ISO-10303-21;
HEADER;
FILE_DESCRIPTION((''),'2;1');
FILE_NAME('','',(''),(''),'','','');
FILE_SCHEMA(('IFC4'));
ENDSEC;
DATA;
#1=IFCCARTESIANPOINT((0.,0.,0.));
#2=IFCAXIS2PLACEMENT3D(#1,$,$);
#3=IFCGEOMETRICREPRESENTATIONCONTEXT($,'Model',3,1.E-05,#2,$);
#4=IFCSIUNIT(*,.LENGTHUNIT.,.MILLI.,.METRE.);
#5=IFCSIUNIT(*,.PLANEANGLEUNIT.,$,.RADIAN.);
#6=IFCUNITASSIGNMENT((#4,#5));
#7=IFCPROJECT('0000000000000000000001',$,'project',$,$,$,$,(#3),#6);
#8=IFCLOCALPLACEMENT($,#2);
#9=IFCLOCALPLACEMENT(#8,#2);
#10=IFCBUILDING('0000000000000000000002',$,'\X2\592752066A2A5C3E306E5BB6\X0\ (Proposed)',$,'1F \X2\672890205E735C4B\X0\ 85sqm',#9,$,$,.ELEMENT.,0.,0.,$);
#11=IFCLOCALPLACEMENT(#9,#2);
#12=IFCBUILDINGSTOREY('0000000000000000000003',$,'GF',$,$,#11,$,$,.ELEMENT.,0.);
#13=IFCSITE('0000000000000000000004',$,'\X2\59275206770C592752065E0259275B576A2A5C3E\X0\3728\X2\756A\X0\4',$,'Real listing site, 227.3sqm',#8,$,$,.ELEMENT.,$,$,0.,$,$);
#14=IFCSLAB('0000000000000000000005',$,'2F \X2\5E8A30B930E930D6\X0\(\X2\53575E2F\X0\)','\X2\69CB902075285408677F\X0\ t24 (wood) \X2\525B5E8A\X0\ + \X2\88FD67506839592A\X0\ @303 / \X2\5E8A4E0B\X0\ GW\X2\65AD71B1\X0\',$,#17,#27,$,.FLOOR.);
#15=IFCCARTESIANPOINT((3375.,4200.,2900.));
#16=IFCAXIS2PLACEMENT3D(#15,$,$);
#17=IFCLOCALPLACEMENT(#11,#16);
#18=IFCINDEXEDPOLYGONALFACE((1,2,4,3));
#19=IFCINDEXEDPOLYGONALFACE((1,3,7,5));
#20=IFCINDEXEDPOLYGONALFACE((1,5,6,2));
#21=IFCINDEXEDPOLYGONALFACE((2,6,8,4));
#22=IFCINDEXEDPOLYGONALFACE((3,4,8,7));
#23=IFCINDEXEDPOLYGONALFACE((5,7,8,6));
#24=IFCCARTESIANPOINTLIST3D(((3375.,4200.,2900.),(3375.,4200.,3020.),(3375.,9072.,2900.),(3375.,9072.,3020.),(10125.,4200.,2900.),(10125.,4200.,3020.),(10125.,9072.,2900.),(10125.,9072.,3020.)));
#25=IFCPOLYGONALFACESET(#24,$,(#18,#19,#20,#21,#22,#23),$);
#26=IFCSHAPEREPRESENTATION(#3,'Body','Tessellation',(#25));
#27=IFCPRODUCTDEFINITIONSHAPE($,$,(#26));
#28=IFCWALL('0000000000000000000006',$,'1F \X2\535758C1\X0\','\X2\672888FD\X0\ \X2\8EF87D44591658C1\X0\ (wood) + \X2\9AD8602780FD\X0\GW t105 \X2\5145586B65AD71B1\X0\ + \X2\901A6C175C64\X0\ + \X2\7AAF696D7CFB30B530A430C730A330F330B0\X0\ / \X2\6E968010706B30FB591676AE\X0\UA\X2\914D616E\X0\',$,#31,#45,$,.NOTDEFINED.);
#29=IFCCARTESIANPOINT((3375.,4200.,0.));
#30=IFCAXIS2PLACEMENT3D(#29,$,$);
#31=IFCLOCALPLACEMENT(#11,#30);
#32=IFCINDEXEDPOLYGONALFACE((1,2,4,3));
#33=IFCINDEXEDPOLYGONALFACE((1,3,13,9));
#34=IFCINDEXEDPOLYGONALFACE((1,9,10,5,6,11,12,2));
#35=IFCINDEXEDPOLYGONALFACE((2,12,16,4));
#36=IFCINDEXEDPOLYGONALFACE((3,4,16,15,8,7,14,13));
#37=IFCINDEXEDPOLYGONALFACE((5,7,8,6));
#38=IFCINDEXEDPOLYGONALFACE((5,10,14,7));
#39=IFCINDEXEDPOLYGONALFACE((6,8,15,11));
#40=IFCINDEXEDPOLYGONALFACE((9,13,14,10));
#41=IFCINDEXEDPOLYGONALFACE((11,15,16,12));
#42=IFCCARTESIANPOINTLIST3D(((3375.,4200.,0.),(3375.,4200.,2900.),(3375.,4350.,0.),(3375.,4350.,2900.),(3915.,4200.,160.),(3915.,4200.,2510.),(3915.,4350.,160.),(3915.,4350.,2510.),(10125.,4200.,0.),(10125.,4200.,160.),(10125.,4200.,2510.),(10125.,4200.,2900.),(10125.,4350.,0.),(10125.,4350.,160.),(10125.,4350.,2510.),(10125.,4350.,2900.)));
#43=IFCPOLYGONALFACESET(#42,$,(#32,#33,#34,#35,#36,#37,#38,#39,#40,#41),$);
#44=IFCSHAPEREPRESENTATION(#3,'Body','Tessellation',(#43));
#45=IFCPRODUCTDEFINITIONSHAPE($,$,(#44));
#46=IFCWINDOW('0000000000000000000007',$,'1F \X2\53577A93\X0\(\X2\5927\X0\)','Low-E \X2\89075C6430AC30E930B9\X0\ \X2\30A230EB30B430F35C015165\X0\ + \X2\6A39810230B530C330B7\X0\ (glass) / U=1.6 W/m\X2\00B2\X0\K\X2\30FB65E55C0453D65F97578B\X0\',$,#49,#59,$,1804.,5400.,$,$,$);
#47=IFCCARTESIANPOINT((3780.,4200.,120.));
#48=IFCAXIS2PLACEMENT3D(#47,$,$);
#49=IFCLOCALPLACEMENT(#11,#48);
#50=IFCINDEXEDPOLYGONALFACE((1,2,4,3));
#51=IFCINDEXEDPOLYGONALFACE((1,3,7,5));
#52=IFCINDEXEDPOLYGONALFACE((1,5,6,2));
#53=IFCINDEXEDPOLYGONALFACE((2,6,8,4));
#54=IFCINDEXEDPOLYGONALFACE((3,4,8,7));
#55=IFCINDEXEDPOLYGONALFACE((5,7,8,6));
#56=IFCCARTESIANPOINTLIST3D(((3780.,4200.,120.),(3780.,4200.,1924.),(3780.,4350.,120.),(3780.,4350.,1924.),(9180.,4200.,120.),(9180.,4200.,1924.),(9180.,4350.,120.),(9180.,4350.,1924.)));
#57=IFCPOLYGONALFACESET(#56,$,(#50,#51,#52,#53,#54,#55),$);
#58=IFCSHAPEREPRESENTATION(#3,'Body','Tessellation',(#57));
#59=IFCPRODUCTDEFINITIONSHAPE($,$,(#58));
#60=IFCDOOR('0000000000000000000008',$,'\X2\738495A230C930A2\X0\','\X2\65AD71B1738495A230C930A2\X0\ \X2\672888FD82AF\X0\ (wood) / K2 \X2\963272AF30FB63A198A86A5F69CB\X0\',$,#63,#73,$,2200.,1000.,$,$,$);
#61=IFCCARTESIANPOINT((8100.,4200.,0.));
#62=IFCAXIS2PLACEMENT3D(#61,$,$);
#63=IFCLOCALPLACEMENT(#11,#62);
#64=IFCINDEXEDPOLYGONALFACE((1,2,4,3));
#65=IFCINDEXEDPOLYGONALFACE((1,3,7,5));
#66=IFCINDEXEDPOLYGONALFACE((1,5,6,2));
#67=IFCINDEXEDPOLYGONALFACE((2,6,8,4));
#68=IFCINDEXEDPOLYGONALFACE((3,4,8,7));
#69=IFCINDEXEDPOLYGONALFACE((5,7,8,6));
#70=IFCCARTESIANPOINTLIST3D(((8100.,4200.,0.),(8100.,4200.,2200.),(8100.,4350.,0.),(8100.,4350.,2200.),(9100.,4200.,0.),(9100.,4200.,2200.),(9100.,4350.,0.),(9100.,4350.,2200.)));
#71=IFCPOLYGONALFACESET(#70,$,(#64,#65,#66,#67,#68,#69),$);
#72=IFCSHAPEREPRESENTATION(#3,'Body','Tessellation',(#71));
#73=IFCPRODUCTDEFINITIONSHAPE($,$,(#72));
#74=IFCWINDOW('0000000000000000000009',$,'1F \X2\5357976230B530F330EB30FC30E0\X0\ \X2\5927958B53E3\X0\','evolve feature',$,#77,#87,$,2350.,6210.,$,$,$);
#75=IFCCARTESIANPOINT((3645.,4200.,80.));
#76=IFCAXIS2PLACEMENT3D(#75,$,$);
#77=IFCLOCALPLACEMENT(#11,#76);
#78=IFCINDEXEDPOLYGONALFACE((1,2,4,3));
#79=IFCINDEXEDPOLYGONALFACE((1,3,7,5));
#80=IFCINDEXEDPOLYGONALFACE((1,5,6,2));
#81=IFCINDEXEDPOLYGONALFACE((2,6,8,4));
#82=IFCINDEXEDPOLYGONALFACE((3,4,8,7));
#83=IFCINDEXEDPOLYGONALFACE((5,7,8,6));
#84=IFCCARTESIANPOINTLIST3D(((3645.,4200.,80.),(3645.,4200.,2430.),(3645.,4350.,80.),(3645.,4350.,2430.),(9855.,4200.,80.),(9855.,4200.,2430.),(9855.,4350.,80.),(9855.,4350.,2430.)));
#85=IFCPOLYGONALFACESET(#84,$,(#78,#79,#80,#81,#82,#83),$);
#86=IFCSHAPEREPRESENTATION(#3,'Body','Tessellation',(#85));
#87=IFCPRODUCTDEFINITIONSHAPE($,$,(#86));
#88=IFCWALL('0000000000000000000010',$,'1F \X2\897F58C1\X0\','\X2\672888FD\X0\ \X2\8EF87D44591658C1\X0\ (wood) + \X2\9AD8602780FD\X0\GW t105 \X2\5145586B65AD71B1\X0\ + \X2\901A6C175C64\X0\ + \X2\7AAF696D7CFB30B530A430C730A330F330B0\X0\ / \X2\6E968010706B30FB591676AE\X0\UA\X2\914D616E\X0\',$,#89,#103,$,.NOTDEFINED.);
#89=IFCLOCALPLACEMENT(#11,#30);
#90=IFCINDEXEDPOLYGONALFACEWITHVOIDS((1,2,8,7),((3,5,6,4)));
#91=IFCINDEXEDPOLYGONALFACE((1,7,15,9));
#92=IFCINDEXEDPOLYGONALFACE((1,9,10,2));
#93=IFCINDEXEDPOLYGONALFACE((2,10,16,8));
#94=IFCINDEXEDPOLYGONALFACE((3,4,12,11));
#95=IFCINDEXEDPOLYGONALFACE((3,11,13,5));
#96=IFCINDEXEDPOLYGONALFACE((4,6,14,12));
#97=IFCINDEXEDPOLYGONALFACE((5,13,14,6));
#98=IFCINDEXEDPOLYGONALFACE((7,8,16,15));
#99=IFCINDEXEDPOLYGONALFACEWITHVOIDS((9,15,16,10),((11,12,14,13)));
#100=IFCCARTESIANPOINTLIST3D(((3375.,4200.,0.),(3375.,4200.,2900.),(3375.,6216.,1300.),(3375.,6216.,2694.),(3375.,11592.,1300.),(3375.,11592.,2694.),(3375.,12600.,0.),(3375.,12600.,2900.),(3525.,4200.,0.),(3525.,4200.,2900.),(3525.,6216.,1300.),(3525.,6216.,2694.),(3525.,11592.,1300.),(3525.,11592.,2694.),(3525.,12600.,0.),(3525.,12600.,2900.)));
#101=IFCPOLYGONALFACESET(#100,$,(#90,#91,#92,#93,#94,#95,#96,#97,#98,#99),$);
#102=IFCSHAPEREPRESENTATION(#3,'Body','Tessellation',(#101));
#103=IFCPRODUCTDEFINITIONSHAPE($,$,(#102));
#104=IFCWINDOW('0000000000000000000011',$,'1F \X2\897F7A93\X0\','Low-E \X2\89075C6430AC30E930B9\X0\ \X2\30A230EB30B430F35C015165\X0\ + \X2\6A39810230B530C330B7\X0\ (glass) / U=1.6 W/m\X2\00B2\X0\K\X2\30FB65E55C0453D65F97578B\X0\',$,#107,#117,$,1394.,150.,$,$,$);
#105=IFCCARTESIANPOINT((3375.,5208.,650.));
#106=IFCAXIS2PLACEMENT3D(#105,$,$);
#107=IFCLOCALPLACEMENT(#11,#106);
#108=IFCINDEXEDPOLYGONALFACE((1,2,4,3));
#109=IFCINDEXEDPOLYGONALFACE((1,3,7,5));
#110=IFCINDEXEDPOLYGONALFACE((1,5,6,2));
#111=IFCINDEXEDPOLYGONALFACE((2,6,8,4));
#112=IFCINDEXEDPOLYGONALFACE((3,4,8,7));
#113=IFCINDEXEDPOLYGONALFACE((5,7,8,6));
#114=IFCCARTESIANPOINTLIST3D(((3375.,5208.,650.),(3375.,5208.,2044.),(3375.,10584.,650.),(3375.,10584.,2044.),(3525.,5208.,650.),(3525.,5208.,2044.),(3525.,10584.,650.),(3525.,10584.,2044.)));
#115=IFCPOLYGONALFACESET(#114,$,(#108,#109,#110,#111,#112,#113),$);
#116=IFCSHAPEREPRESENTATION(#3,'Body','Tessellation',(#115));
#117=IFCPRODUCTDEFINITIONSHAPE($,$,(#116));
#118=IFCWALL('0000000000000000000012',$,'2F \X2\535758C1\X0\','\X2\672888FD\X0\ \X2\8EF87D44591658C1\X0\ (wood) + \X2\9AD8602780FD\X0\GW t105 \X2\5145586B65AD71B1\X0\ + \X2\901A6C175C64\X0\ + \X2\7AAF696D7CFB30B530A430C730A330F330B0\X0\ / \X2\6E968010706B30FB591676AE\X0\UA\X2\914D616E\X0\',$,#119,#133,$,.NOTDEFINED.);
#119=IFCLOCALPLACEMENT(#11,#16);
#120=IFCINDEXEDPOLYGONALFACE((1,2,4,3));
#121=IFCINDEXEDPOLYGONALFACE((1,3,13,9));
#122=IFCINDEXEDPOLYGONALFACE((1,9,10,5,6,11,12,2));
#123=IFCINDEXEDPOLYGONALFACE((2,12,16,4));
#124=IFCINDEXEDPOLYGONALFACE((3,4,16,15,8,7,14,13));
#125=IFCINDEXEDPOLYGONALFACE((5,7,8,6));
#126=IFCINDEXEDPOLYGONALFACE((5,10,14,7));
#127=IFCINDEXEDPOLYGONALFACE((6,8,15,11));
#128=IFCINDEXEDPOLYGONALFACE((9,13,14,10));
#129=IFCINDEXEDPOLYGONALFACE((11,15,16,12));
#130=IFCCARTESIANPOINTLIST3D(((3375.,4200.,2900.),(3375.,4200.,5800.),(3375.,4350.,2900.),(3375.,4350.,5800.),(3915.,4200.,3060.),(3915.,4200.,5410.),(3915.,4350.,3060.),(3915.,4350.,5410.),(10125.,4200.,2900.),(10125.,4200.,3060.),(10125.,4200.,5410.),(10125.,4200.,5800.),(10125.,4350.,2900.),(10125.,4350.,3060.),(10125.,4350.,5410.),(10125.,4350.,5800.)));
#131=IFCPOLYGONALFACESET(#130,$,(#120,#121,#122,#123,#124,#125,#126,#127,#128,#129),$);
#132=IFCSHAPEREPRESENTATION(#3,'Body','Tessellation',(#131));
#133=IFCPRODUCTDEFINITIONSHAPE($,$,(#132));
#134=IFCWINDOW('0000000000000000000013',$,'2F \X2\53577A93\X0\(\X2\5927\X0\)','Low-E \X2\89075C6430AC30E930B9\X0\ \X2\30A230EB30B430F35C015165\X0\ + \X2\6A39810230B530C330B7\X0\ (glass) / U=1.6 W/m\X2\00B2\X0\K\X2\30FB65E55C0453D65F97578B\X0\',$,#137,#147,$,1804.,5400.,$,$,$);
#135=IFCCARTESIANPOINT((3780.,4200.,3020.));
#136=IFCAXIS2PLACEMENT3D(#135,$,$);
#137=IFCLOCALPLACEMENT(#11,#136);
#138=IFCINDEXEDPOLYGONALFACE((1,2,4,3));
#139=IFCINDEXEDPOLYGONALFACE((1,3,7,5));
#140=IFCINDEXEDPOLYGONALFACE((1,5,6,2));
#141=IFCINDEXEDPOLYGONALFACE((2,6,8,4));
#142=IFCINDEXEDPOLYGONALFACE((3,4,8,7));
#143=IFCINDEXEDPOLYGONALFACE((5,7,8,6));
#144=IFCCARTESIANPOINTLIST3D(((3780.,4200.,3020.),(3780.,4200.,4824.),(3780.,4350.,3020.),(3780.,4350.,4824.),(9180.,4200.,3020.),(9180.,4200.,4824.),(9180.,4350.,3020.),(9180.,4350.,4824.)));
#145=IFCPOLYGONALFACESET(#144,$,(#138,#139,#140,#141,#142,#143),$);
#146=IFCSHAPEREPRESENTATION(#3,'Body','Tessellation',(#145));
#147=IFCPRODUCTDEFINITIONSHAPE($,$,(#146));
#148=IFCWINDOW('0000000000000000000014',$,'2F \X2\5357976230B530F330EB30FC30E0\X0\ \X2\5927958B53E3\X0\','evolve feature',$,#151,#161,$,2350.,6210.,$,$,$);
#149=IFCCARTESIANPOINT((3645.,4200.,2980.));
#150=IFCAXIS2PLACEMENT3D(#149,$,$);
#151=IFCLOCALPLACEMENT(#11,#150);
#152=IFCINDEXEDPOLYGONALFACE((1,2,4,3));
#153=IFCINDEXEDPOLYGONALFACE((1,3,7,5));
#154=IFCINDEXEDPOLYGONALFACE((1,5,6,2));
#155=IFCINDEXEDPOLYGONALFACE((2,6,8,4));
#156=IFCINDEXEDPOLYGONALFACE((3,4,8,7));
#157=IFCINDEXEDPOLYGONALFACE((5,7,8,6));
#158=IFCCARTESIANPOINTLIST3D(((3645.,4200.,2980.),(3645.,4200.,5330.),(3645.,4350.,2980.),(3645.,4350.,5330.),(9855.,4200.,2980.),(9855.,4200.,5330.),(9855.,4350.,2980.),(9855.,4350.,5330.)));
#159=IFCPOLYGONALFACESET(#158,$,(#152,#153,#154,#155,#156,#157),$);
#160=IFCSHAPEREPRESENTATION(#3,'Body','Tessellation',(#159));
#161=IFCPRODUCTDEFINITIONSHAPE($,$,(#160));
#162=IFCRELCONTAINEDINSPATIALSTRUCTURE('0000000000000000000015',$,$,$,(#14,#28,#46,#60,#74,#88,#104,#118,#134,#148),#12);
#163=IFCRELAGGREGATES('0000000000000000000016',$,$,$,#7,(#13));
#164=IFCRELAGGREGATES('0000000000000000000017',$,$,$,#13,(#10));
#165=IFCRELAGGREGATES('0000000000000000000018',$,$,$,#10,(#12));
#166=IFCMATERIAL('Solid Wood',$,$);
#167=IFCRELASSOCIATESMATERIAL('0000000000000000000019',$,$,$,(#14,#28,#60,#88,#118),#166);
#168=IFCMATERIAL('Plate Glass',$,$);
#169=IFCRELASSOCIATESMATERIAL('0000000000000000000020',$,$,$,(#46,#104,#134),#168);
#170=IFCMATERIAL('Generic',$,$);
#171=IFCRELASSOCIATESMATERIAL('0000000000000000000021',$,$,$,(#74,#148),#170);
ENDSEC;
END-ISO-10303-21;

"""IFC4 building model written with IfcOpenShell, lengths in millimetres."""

from ifc_helpers import new_model, si_unit, frame, frame_2d, origin, place, context, project, spatial, rectangle, extrude, material, element, fill, save


model = new_model("IFC4")

# Units and contexts
model_context = context("Model", 3, precision=1e-05, world=origin())
ifc_project = project(units=[si_unit("LENGTHUNIT", "METRE", prefix="MILLI"), si_unit("PLANEANGLEUNIT", "RADIAN")], contexts=[model_context])

# Site, building, storey
site_placement = place(None, origin())
site = spatial("IfcSite", under=ifc_project, at=site_placement, Name="大分県大分市大字横尾3728番4", ObjectType="Real listing site, 227.3sqm", CompositionType="ELEMENT", RefElevation=0.0)
building_placement = place(site_placement, origin())
building = spatial("IfcBuilding", under=site, at=building_placement, Name="大分横尾の家 (Proposed)", ObjectType="1F 木造平屋 85sqm", CompositionType="ELEMENT", ElevationOfRefHeight=0.0, ElevationOfTerrain=0.0)
storey_placement = place(building_placement, origin())
storey = spatial("IfcBuildingStorey", under=building, at=storey_placement, Name="GF", CompositionType="ELEMENT", Elevation=0.0)

# Slab
ifc_material_1 = material(Name="Solid Wood")
slab_1_placement = place(storey_placement, frame((3375.0, 4200.0, 2900.0)))
element("IfcSlab", 1, at=slab_1_placement, inside=storey, material=ifc_material_1, Name="2F 床スラブ(南帯)", Description="構造用合板 t24 (wood) 剛床 + 製材根太 @303 / 床下 GW断熱", PredefinedType="FLOOR", context=model_context, shape_type="SweptSolid", body=[
    extrude(rectangle(XDim=6750.0, YDim=4872.0, at=frame_2d((3375.0, 2436.0))), frame((3375.0, 4200.0, 2900.0)), (0.0, 0.0, 1.0), 120.0),
])
ifc_material_2 = material(Name="Generic")

# Wall, openings, windows, door
wall_1_placement = place(storey_placement, frame((3375.0, 4200.0, 0.0)))
wall_1 = element("IfcWall", 2, at=wall_1_placement, inside=storey, material=ifc_material_1, Name="1F 南壁", Description="木製 軸組外壁 (wood) + 高性能GW t105 充填断熱 + 通気層 + 窯業系サイディング / 準耐火・外皮UA配慮", PredefinedType="NOTDEFINED", context=model_context, shape_type="SweptSolid", body=[
    extrude(rectangle(XDim=6750.0, YDim=150.0, at=frame_2d((3375.0, 75.0))), frame((3375.0, 4200.0, 0.0)), (0.0, 0.0, 1.0), 2900.0),
])
opening_1_placement = place(storey_placement, frame((3780.0, 4200.0, 120.0)))
opening_1 = element("IfcOpeningElement", 3, at=opening_1_placement, cuts=wall_1, PredefinedType="NOTDEFINED", context=model_context, shape_type="SweptSolid", body=[
    extrude(rectangle(XDim=5400.0, YDim=150.0, at=frame_2d((2700.0, 75.0))), frame((3780.0, 4200.0, 120.0)), (0.0, 0.0, 1.0), 1804.0),
])
opening_2_placement = place(storey_placement, frame((8100.0, 4200.0, 0.0)))
opening_2 = element("IfcOpeningElement", 4, at=opening_2_placement, cuts=wall_1, PredefinedType="NOTDEFINED", context=model_context, shape_type="SweptSolid", body=[
    extrude(rectangle(XDim=1000.0, YDim=150.0, at=frame_2d((500.0, 75.0))), frame((8100.0, 4200.0, 0.0)), (0.0, 0.0, 1.0), 2200.0),
])
opening_3_placement = place(storey_placement, frame((3645.0, 4200.0, 80.0)))
opening_3 = element("IfcOpeningElement", 5, at=opening_3_placement, cuts=wall_1, PredefinedType="NOTDEFINED", context=model_context, shape_type="SweptSolid", body=[
    extrude(rectangle(XDim=6210.0, YDim=150.0, at=frame_2d((3105.0, 75.0))), frame((3645.0, 4200.0, 80.0)), (0.0, 0.0, 1.0), 2350.0),
])
ifc_material_3 = material(Name="Plate Glass")
window_1_placement = place(storey_placement, frame((3780.0, 4200.0, 120.0)))
window_1 = element("IfcWindow", 6, at=window_1_placement, inside=storey, material=ifc_material_3, Name="1F 南窓(大)", Description="Low-E 複層ガラス アルゴン封入 + 樹脂サッシ (glass) / U=1.6 W/m²K・日射取得型", OverallHeight=1804.0, OverallWidth=5400.0, context=model_context, shape_type="SweptSolid", body=[
    extrude(rectangle(XDim=5400.0, YDim=150.0, at=frame_2d((2700.0, 75.0))), frame((3780.0, 4200.0, 120.0)), (0.0, 0.0, 1.0), 1804.0),
])
fill(opening_1, window_1)
door_placement = place(storey_placement, frame((8100.0, 4200.0, 0.0)))
door = element("IfcDoor", 7, at=door_placement, inside=storey, material=ifc_material_1, Name="玄関ドア", Description="断熱玄関ドア 木製芯 (wood) / K2 防犯・採風機構", OverallHeight=2200.0, OverallWidth=1000.0, context=model_context, shape_type="SweptSolid", body=[
    extrude(rectangle(XDim=1000.0, YDim=150.0, at=frame_2d((500.0, 75.0))), frame((8100.0, 4200.0, 0.0)), (0.0, 0.0, 1.0), 2200.0),
])
fill(opening_2, door)
window_2_placement = place(storey_placement, frame((3645.0, 4200.0, 80.0)))
window_2 = element("IfcWindow", 8, at=window_2_placement, inside=storey, material=ifc_material_2, Name="1F 南面サンルーム 大開口", Description="evolve feature", OverallHeight=2350.0, OverallWidth=6210.0, context=model_context, shape_type="SweptSolid", body=[
    extrude(rectangle(XDim=6210.0, YDim=150.0, at=frame_2d((3105.0, 75.0))), frame((3645.0, 4200.0, 80.0)), (0.0, 0.0, 1.0), 2350.0),
])
fill(opening_3, window_2)

# Wall, opening, window
wall_2_placement = place(storey_placement, frame((3375.0, 4200.0, 0.0)))
wall_2 = element("IfcWall", 9, at=wall_2_placement, inside=storey, material=ifc_material_1, Name="1F 西壁", Description="木製 軸組外壁 (wood) + 高性能GW t105 充填断熱 + 通気層 + 窯業系サイディング / 準耐火・外皮UA配慮", PredefinedType="NOTDEFINED", context=model_context, shape_type="SweptSolid", body=[
    extrude(rectangle(XDim=150.0, YDim=8400.0, at=frame_2d((75.0, 4200.0))), frame((3375.0, 4200.0, 0.0)), (0.0, 0.0, 1.0), 2900.0),
])
opening_4_placement = place(storey_placement, frame((3375.0, 5208.0, 650.0)))
opening_4 = element("IfcOpeningElement", 10, at=opening_4_placement, cuts=wall_2, PredefinedType="NOTDEFINED", context=model_context, shape_type="SweptSolid", body=[
    extrude(rectangle(XDim=150.0, YDim=5376.0, at=frame_2d((75.0, 2688.0))), frame((3375.0, 5208.0, 650.0)), (0.0, 0.0, 1.0), 1394.0),
])
window_3_placement = place(storey_placement, frame((3375.0, 5208.0, 650.0)))
window_3 = element("IfcWindow", 11, at=window_3_placement, inside=storey, material=ifc_material_3, Name="1F 西窓", Description="Low-E 複層ガラス アルゴン封入 + 樹脂サッシ (glass) / U=1.6 W/m²K・日射取得型", OverallHeight=1394.0, OverallWidth=150.0, context=model_context, shape_type="SweptSolid", body=[
    extrude(rectangle(XDim=150.0, YDim=5376.0, at=frame_2d((75.0, 2688.0))), frame((3375.0, 5208.0, 650.0)), (0.0, 0.0, 1.0), 1394.0),
])
fill(opening_4, window_3)

# Wall, openings, windows
wall_3_placement = place(storey_placement, frame((3375.0, 4200.0, 2900.0)))
wall_3 = element("IfcWall", 12, at=wall_3_placement, inside=storey, material=ifc_material_1, Name="2F 南壁", Description="木製 軸組外壁 (wood) + 高性能GW t105 充填断熱 + 通気層 + 窯業系サイディング / 準耐火・外皮UA配慮", PredefinedType="NOTDEFINED", context=model_context, shape_type="SweptSolid", body=[
    extrude(rectangle(XDim=6750.0, YDim=150.0, at=frame_2d((3375.0, 75.0))), frame((3375.0, 4200.0, 2900.0)), (0.0, 0.0, 1.0), 2900.0),
])
opening_5_placement = place(storey_placement, frame((3780.0, 4200.0, 3020.0)))
opening_5 = element("IfcOpeningElement", 13, at=opening_5_placement, cuts=wall_3, PredefinedType="NOTDEFINED", context=model_context, shape_type="SweptSolid", body=[
    extrude(rectangle(XDim=5400.0, YDim=150.0, at=frame_2d((2700.0, 75.0))), frame((3780.0, 4200.0, 3020.0)), (0.0, 0.0, 1.0), 1804.0),
])
opening_6_placement = place(storey_placement, frame((3645.0, 4200.0, 2980.0)))
opening_6 = element("IfcOpeningElement", 14, at=opening_6_placement, cuts=wall_3, PredefinedType="NOTDEFINED", context=model_context, shape_type="SweptSolid", body=[
    extrude(rectangle(XDim=6210.0, YDim=150.0, at=frame_2d((3105.0, 75.0))), frame((3645.0, 4200.0, 2980.0)), (0.0, 0.0, 1.0), 2350.0),
])
window_4_placement = place(storey_placement, frame((3780.0, 4200.0, 3020.0)))
window_4 = element("IfcWindow", 15, at=window_4_placement, inside=storey, material=ifc_material_3, Name="2F 南窓(大)", Description="Low-E 複層ガラス アルゴン封入 + 樹脂サッシ (glass) / U=1.6 W/m²K・日射取得型", OverallHeight=1804.0, OverallWidth=5400.0, context=model_context, shape_type="SweptSolid", body=[
    extrude(rectangle(XDim=5400.0, YDim=150.0, at=frame_2d((2700.0, 75.0))), frame((3780.0, 4200.0, 3020.0)), (0.0, 0.0, 1.0), 1804.0),
])
fill(opening_5, window_4)
window_5_placement = place(storey_placement, frame((3645.0, 4200.0, 2980.0)))
window_5 = element("IfcWindow", 16, at=window_5_placement, inside=storey, material=ifc_material_2, Name="2F 南面サンルーム 大開口", Description="evolve feature", OverallHeight=2350.0, OverallWidth=6210.0, context=model_context, shape_type="SweptSolid", body=[
    extrude(rectangle(XDim=6210.0, YDim=150.0, at=frame_2d((3105.0, 75.0))), frame((3645.0, 4200.0, 2980.0)), (0.0, 0.0, 1.0), 2350.0),
])
fill(opening_6, window_5)

save(model, "model.ifc")
